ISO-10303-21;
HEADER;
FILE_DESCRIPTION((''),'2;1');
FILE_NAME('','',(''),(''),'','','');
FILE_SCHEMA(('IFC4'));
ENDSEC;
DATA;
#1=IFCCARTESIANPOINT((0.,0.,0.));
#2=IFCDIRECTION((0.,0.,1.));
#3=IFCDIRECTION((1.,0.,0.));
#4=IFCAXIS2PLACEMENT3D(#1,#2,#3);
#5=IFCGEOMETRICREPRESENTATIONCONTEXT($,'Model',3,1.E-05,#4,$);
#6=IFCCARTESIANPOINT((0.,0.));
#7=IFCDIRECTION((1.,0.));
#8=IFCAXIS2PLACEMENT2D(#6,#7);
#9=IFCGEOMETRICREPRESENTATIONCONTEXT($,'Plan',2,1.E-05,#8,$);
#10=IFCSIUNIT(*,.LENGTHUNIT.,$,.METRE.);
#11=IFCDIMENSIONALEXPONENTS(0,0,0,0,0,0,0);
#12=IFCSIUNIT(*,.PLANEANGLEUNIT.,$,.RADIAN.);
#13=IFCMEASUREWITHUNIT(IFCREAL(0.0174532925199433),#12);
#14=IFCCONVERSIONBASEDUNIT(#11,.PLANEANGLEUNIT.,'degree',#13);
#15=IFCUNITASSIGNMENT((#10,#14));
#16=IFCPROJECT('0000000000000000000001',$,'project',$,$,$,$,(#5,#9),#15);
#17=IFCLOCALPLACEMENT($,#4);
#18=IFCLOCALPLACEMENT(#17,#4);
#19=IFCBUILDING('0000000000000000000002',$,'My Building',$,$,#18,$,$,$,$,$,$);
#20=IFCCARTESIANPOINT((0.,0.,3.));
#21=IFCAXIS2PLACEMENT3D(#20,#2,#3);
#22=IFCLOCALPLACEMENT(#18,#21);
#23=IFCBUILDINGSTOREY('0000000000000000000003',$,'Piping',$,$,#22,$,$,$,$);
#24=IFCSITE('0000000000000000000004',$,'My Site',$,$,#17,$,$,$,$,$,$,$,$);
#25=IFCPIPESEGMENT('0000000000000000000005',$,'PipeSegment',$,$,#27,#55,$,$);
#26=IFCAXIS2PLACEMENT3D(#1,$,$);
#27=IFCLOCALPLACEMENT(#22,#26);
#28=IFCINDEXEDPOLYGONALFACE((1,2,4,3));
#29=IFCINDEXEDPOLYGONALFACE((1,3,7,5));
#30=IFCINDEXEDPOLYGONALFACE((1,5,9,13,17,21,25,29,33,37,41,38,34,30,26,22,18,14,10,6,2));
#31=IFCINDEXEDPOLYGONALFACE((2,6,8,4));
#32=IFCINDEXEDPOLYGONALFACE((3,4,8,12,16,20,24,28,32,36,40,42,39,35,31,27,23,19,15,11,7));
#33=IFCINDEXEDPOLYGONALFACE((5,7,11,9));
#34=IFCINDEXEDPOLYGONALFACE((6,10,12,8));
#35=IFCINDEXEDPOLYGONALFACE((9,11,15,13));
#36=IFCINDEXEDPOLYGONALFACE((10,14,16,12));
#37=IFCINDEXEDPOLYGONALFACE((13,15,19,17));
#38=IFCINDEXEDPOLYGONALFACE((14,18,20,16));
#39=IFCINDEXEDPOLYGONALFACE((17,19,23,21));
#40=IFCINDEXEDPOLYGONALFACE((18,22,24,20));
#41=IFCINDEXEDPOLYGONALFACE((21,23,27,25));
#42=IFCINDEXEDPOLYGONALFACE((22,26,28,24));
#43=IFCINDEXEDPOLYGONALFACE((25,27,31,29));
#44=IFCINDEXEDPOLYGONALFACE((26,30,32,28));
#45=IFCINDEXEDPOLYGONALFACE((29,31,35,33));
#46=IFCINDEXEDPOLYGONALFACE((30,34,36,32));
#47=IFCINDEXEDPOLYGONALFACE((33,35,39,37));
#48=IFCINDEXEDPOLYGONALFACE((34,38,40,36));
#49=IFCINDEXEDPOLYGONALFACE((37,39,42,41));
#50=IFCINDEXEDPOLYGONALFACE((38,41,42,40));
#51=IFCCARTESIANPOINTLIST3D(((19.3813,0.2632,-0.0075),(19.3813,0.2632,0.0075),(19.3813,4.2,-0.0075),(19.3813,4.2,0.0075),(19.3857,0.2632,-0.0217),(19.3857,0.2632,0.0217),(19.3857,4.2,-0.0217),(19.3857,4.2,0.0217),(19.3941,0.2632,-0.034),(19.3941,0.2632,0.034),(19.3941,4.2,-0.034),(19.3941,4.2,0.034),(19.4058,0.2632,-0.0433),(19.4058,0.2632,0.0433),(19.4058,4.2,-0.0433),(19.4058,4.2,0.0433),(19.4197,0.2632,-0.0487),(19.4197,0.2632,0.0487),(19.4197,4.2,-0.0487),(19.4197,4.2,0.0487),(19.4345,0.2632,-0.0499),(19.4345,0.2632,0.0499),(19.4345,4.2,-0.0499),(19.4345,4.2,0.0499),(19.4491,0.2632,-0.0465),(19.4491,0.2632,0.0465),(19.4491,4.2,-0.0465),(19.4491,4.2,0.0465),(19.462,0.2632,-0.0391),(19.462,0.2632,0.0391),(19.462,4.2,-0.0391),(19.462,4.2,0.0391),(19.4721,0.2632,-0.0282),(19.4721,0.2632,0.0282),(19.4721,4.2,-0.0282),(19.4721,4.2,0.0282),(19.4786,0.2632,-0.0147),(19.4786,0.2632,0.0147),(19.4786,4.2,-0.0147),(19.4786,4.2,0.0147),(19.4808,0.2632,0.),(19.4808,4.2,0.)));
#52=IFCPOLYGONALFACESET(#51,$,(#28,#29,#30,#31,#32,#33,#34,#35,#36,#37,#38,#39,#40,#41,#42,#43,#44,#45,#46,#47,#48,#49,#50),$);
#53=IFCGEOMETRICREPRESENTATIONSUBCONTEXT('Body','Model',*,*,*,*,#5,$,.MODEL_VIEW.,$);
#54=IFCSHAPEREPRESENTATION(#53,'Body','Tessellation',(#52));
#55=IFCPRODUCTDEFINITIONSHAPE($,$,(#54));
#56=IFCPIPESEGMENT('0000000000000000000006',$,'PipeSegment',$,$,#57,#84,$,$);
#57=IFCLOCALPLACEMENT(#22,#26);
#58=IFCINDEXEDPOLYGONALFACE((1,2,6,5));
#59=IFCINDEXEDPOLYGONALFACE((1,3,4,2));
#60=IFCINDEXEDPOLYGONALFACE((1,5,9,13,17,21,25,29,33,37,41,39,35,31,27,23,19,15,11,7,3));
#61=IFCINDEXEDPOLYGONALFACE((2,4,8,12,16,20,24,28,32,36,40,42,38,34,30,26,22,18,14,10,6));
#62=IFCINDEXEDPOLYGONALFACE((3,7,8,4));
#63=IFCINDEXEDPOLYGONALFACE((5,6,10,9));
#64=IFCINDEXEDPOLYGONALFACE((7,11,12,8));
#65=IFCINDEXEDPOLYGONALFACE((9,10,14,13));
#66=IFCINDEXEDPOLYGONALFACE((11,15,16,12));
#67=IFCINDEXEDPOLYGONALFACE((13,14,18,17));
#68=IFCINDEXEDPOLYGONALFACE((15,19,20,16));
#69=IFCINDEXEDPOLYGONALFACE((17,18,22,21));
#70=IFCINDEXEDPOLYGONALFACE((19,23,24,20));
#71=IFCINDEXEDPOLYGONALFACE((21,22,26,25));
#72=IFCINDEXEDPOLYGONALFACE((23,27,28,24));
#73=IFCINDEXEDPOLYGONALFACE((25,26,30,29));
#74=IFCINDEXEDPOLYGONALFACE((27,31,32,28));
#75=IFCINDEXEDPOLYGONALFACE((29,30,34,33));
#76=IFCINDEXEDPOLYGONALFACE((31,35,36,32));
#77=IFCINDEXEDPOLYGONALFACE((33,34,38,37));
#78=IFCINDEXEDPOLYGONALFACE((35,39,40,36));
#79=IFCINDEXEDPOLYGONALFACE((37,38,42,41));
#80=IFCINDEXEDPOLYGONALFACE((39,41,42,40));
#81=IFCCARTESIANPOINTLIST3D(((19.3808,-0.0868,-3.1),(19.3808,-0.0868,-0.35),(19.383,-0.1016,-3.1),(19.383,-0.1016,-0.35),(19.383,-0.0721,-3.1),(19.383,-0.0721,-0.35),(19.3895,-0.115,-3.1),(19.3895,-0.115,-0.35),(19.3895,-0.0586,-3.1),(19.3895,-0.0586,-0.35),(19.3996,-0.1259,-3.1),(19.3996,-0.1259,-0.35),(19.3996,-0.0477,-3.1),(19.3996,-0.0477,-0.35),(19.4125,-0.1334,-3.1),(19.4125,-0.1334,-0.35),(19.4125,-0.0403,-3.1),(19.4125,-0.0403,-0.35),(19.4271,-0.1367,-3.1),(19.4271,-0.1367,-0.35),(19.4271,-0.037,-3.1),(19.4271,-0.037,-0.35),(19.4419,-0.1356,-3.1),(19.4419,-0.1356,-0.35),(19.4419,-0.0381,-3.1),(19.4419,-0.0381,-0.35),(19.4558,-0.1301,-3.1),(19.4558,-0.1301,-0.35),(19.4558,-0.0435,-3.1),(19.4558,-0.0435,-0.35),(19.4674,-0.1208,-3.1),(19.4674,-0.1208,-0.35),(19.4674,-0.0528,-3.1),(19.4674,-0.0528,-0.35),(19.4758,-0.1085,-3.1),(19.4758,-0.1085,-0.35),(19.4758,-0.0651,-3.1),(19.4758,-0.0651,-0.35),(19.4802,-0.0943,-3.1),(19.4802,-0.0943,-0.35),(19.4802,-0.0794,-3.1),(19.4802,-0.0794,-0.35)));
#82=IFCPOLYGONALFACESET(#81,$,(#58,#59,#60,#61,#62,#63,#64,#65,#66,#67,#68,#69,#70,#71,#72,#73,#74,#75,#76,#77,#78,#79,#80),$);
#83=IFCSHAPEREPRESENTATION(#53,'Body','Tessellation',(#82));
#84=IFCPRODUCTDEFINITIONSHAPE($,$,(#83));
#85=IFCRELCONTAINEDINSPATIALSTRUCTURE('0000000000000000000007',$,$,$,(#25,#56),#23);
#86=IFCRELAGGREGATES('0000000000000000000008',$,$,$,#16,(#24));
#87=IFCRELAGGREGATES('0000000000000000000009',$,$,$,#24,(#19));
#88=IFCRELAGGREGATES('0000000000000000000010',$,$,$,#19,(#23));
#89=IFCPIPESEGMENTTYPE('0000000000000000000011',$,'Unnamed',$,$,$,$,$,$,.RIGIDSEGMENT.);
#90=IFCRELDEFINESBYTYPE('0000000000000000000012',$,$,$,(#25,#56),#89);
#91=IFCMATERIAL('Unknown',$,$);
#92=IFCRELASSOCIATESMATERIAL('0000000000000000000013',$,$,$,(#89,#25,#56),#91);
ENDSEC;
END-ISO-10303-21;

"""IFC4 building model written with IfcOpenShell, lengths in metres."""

from ifc_helpers import new_model, entity, si_unit, converted_unit, frame, origin_with_axes, origin_2d_with_axis, place, context, subcontext, project, spatial, circle, extrude, material, material_profile, profile_set, profile_usage, type_object, element, save


model = new_model("IFC4")

# Units and contexts
model_context = context("Model", 3, precision=1e-05, world=origin_with_axes())
plan_context = context("Plan", 2, precision=1e-05, world=origin_2d_with_axis())
body_context = subcontext(model_context, "Body", "Model", "MODEL_VIEW")
ifc_project = project(units=[si_unit("LENGTHUNIT", "METRE"), converted_unit("PLANEANGLEUNIT", "degree", entity("IfcReal", 0.0174532925199433), si_unit("PLANEANGLEUNIT", "RADIAN"), dimensions=[0, 0, 0, 0, 0, 0, 0])], contexts=[model_context, plan_context])

# Site, building, storey
site_placement = place(None, origin_with_axes())
site = spatial("IfcSite", under=ifc_project, at=site_placement, Name="My Site")
building_placement = place(site_placement, origin_with_axes())
building = spatial("IfcBuilding", under=site, at=building_placement, Name="My Building")
storey_placement = place(building_placement, frame((0.0, 0.0, 3.0), z_axis=(0.0, 0.0, 1.0), x_axis=(1.0, 0.0, 0.0)))
storey = spatial("IfcBuildingStorey", under=building, at=storey_placement, Name="Piping")

# Pipe segments
ifc_material = material(Name="Unknown")
ifc_material_profile_1 = material_profile(ifc_material, circle(Radius=0.05))
ifc_profile_set_1 = profile_set([ifc_material_profile_1])
pipe_segment_type = type_object("IfcPipeSegmentType", Name="Unnamed", PredefinedType="RIGIDSEGMENT", material=ifc_profile_set_1)
ifc_profile_usage_1 = profile_usage(ifc_profile_set_1, cardinal=5)
pipe_segment_1_placement = place(storey_placement, frame((19.4308, 4.2, 0.0), z_axis=(0.0, -1.0, 0.0), x_axis=(1.0, 0.0, 0.0)))
element("IfcPipeSegment", 1, at=pipe_segment_1_placement, inside=storey, type_object=pipe_segment_type, material=ifc_profile_usage_1, Name="PipeSegment", context=body_context, shape_type="SweptSolid", body=[
    extrude(circle(Radius=0.05), origin_with_axes(), (0.0, 0.0, 1.0), 3.9368),
])
ifc_profile_usage_2 = profile_usage(ifc_profile_set_1, cardinal=5)
pipe_segment_2_placement = place(storey_placement, frame((19.4308, -0.0868, -0.35), z_axis=(0.0, 0.0, -1.0), x_axis=(-1.0, 0.0, 0.0)))
element("IfcPipeSegment", 2, at=pipe_segment_2_placement, inside=storey, type_object=pipe_segment_type, material=ifc_profile_usage_2, Name="PipeSegment", context=body_context, shape_type="SweptSolid", body=[
    extrude(circle(Radius=0.05), origin_with_axes(), (0.0, 0.0, 1.0), 2.75),
])

save(model, "model.ifc")
